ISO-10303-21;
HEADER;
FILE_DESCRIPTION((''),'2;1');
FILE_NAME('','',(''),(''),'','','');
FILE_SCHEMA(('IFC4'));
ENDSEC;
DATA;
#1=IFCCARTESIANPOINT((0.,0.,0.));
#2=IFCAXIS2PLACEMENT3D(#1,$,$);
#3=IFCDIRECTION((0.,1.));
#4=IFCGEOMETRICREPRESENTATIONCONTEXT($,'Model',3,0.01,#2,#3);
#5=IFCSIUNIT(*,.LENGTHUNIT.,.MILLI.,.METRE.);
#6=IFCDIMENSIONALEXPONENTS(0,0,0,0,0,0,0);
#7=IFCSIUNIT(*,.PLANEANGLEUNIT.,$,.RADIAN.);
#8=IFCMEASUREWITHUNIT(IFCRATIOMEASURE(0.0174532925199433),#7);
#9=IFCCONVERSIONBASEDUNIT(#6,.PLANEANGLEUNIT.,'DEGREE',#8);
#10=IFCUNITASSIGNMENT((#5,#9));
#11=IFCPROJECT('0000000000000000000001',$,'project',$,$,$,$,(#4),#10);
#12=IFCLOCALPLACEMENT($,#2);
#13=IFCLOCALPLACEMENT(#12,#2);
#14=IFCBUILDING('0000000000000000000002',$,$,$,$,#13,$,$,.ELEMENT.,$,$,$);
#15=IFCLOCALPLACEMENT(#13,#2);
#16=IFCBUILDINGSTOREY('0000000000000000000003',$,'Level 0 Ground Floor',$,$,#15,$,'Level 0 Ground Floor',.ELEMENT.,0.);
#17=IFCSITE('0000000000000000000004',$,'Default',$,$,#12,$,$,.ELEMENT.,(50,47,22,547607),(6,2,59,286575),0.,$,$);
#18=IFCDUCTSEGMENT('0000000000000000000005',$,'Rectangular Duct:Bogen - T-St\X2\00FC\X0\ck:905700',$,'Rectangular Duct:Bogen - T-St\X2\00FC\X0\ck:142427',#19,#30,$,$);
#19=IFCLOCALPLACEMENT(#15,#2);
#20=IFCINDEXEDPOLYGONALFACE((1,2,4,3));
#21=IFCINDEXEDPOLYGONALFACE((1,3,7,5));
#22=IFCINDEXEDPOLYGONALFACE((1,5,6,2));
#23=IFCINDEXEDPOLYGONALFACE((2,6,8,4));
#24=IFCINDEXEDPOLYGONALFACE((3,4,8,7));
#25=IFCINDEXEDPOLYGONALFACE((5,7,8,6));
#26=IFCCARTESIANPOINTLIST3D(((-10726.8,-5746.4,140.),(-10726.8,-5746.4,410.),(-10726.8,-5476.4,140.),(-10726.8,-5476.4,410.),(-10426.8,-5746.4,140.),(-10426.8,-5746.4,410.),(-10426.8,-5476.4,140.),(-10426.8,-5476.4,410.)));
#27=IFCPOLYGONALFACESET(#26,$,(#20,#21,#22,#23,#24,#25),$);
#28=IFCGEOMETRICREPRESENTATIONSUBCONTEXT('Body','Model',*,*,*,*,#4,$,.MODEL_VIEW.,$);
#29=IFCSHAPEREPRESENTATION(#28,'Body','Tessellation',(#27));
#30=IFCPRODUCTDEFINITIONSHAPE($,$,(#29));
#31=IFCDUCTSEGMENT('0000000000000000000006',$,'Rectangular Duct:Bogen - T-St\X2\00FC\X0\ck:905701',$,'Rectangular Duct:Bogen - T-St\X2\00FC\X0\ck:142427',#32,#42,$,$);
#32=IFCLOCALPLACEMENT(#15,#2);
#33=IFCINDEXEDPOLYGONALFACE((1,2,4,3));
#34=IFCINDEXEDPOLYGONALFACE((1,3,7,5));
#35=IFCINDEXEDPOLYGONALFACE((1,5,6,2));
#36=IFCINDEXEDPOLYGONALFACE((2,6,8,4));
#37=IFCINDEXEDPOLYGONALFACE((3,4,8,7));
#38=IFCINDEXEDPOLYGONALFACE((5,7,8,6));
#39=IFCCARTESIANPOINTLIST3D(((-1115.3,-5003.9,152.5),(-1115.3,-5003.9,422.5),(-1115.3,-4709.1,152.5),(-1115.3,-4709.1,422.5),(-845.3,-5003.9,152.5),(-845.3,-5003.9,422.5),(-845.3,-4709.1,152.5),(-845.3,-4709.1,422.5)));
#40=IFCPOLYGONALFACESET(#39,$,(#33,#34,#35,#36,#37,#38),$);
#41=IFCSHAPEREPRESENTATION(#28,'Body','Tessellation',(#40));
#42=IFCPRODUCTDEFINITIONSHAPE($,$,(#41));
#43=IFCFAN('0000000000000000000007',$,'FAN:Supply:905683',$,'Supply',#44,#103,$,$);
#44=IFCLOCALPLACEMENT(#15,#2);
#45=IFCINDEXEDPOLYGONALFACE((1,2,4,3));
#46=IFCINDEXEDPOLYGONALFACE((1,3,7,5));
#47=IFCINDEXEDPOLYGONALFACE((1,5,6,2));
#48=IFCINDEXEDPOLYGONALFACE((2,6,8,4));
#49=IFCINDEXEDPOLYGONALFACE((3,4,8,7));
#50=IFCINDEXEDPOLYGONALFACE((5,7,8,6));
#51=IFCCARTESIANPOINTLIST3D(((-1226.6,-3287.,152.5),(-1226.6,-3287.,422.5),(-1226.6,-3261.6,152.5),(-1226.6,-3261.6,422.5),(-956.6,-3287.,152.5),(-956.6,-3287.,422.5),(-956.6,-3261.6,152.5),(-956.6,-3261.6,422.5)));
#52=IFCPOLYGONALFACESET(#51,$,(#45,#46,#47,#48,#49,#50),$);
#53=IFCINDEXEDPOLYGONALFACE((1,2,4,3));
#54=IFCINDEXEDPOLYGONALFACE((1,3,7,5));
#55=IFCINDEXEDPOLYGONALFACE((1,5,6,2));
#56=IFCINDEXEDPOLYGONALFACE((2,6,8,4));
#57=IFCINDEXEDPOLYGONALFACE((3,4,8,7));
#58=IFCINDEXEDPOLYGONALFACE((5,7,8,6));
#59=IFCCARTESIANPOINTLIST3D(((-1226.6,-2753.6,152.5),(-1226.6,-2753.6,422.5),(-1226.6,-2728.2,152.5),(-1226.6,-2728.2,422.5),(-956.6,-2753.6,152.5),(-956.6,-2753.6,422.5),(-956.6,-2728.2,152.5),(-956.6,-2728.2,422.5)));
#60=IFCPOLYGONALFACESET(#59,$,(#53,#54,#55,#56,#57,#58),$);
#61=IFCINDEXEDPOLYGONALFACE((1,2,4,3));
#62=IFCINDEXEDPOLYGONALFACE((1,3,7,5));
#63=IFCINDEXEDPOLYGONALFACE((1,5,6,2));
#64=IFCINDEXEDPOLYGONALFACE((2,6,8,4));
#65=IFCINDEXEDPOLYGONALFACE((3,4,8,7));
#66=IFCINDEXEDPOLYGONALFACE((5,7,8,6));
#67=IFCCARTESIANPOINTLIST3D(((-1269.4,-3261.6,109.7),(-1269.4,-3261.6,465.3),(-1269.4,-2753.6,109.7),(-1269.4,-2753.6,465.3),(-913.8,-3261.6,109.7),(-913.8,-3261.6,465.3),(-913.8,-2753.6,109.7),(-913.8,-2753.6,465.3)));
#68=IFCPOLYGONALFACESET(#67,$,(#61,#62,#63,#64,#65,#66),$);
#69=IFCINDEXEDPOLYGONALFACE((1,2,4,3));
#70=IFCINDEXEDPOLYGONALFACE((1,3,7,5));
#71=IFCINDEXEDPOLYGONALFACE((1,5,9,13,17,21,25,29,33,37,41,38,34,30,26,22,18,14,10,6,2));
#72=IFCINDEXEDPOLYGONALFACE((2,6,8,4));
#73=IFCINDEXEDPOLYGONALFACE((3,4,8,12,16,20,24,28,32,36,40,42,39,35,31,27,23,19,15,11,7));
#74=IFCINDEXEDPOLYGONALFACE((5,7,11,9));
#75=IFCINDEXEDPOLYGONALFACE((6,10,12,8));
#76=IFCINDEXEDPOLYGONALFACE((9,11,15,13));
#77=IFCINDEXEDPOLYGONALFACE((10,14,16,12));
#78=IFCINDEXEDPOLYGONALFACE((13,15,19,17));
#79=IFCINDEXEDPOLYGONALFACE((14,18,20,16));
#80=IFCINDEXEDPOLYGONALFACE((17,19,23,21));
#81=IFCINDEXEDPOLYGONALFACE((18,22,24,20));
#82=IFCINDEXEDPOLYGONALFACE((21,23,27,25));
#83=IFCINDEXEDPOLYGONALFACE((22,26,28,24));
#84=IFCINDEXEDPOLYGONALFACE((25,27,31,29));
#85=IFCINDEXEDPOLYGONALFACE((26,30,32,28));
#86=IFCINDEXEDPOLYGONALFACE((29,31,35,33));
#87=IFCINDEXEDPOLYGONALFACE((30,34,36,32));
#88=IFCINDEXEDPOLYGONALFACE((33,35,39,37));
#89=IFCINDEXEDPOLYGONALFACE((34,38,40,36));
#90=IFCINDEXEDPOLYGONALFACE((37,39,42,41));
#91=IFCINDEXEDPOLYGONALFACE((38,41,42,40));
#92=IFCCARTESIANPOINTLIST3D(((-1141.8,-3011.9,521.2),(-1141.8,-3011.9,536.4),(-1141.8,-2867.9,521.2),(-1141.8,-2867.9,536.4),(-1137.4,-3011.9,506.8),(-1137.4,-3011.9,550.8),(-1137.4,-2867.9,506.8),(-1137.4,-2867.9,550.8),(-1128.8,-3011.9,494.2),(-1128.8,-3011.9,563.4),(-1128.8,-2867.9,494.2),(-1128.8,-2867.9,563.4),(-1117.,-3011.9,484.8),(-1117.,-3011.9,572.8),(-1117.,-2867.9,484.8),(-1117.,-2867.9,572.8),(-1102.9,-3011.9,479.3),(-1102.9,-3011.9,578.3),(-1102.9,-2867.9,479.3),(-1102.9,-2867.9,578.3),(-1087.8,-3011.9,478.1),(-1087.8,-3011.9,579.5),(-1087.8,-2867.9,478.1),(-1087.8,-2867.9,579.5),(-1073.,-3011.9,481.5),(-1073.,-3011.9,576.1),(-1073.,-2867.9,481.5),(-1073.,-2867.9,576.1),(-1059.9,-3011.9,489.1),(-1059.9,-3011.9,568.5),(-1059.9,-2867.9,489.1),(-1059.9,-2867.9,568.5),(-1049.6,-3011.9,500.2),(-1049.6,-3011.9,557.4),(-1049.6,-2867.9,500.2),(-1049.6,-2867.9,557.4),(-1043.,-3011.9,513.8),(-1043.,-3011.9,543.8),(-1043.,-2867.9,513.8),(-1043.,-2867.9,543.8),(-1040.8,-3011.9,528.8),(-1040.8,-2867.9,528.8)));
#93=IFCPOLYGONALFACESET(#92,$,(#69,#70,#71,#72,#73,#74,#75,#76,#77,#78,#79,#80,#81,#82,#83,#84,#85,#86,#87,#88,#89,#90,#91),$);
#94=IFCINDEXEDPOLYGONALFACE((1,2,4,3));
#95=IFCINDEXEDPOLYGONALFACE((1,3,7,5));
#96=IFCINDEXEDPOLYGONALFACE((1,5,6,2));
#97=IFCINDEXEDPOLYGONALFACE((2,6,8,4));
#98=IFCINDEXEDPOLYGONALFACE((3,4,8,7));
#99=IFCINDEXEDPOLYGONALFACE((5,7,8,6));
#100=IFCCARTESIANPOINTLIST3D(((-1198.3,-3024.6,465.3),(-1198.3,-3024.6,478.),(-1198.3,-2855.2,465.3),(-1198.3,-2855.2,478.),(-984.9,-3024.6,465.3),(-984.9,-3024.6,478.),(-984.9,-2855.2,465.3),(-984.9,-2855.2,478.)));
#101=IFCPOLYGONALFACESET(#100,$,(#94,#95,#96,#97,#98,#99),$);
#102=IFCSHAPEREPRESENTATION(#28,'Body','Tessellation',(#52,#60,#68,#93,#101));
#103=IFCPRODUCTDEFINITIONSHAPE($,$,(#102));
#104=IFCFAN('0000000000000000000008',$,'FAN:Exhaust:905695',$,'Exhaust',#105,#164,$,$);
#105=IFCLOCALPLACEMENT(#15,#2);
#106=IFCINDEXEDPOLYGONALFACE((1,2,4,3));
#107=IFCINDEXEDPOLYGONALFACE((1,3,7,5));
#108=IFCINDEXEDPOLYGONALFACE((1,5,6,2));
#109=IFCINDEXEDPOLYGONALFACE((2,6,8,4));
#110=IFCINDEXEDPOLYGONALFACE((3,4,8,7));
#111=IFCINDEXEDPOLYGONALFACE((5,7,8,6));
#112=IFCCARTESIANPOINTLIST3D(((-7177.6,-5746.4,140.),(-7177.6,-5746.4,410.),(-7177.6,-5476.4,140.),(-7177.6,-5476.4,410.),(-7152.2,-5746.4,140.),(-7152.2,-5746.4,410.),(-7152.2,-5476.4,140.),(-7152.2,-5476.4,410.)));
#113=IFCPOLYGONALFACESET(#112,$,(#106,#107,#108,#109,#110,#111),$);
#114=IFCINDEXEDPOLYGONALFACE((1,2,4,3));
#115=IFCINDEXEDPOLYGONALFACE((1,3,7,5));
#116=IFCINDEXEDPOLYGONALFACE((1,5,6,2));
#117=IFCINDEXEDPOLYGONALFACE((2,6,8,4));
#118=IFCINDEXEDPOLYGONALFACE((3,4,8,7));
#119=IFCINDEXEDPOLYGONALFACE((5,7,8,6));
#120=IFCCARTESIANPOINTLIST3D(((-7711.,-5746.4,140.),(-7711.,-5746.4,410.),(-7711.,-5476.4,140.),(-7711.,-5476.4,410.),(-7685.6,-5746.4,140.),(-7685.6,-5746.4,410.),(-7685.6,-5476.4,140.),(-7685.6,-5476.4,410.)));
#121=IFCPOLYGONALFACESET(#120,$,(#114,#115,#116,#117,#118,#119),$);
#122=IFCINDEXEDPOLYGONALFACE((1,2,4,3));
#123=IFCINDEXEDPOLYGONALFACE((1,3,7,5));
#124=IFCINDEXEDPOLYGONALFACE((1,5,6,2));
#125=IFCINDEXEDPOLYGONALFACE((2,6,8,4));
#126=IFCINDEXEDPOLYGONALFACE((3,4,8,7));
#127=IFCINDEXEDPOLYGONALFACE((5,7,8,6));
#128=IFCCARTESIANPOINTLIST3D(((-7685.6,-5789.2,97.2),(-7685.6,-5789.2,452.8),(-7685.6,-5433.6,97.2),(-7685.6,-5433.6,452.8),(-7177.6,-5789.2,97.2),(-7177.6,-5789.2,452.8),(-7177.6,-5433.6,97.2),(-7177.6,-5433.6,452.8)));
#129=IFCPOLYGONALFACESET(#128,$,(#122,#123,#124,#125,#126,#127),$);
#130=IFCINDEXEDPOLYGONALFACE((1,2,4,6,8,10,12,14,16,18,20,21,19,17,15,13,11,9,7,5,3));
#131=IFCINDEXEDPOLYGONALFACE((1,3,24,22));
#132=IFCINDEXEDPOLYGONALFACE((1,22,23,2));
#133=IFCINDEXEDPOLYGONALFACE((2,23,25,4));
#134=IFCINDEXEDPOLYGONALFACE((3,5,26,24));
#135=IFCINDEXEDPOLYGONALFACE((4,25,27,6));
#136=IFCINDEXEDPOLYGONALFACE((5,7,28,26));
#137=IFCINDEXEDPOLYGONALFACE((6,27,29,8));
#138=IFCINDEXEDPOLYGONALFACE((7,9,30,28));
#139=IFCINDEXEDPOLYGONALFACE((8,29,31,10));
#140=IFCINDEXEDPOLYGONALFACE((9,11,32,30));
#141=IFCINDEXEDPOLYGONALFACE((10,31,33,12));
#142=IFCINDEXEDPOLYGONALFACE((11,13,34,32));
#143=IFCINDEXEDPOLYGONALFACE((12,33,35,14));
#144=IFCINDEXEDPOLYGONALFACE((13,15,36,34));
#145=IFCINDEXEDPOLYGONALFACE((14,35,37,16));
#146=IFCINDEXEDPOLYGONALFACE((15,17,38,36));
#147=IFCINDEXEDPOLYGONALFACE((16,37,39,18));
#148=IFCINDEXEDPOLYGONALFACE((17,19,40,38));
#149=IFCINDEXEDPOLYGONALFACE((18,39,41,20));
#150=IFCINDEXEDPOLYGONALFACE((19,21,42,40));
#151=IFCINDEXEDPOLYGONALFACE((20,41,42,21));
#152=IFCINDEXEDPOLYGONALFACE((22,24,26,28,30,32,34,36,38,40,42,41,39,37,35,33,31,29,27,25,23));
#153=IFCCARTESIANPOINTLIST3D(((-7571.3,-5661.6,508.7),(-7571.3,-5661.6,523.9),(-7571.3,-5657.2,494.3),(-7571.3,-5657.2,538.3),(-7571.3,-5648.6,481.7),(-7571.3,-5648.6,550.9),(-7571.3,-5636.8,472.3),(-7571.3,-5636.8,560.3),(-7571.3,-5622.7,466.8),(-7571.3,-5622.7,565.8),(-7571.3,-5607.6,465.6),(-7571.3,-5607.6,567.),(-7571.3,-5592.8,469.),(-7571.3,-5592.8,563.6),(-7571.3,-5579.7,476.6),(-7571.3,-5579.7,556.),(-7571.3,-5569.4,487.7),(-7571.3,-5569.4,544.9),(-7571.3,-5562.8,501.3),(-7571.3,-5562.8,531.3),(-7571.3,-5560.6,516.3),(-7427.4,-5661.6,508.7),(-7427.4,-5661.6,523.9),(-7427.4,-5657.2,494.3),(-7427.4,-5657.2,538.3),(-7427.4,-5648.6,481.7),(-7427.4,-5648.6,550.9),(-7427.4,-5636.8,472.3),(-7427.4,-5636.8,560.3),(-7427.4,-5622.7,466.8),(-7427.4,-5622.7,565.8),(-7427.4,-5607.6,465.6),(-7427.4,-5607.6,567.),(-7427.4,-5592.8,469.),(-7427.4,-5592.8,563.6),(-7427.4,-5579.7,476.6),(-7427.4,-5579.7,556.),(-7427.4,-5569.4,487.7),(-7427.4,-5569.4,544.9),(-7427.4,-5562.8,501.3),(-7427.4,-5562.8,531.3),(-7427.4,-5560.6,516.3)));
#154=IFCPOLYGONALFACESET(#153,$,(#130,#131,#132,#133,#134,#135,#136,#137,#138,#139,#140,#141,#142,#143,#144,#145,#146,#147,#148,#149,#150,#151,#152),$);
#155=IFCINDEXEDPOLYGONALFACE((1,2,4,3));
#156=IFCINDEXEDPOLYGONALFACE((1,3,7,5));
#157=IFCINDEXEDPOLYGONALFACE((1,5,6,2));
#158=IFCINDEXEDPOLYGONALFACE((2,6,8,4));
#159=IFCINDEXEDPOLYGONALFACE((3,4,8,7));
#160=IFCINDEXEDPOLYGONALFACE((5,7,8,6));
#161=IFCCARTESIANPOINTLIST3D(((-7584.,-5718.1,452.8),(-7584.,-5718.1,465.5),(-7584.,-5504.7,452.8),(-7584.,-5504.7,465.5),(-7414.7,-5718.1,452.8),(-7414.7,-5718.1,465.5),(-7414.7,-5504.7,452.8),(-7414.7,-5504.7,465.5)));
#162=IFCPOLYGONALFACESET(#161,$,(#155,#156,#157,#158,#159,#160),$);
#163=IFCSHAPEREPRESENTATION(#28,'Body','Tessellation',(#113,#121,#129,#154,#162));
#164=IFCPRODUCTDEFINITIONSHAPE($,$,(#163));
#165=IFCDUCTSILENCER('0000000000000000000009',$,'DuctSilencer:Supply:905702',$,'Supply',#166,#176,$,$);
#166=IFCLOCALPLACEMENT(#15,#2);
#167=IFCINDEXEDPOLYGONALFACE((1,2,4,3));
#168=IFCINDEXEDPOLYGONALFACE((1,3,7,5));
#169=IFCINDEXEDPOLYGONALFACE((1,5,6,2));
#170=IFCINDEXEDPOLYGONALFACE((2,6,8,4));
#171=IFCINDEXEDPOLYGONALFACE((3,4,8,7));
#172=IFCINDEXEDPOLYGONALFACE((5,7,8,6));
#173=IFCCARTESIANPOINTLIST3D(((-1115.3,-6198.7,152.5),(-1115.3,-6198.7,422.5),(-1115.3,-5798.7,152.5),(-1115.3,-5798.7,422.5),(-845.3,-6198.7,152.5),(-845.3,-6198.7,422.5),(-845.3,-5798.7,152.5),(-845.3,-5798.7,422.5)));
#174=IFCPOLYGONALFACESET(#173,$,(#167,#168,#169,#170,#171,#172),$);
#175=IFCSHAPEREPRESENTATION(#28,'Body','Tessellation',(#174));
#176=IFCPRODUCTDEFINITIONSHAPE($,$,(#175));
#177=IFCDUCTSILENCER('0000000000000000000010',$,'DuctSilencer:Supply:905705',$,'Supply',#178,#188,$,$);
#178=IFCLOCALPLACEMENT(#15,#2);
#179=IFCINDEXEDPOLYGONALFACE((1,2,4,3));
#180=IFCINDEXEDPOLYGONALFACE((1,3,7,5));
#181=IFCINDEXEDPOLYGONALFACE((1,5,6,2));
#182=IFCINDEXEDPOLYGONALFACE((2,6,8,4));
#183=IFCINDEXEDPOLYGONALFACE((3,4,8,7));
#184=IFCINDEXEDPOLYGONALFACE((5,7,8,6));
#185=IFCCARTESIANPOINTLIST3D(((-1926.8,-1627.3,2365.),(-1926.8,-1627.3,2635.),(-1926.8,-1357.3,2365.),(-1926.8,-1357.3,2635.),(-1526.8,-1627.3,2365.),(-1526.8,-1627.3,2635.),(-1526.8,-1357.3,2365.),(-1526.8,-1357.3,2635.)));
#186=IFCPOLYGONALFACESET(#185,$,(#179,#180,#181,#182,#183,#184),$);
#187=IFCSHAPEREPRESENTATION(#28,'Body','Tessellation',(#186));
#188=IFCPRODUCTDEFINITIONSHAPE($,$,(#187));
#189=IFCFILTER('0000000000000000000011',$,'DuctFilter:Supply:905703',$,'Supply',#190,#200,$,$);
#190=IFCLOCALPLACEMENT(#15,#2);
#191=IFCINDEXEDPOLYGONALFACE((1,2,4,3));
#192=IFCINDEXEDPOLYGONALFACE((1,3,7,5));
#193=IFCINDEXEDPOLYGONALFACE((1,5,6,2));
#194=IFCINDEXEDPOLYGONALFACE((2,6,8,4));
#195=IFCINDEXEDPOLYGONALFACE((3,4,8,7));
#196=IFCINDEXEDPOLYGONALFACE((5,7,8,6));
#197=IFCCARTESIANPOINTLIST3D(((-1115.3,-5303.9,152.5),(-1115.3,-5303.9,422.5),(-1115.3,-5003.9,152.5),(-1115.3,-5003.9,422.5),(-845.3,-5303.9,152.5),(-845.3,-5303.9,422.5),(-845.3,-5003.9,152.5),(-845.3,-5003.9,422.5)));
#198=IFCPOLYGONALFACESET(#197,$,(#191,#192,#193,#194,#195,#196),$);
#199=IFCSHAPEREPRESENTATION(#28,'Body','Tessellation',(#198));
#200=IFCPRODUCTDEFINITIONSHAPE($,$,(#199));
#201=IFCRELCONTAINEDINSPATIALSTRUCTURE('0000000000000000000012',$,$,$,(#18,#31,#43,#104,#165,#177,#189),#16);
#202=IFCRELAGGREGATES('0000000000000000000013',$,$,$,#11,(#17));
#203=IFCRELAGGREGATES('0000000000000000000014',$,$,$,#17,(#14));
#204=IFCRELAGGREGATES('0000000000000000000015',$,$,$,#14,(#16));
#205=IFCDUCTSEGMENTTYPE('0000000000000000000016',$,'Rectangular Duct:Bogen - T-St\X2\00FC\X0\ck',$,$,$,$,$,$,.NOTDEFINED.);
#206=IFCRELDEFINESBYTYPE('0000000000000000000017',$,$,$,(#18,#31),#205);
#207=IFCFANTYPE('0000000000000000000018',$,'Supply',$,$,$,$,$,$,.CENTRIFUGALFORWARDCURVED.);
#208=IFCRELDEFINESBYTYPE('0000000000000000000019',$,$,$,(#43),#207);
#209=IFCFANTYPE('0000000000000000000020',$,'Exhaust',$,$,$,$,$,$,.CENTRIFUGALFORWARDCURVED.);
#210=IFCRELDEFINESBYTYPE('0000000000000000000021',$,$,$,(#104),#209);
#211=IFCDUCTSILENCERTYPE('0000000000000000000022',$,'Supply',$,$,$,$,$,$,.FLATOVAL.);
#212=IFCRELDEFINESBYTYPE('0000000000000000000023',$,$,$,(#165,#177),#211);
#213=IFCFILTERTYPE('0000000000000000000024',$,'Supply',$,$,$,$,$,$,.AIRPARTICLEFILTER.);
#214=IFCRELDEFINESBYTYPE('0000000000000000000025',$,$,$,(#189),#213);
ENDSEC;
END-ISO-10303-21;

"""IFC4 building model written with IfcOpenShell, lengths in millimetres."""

from ifc_helpers import new_model, entity, si_unit, converted_unit, direction, frame, frame_2d, origin, origin_2d_with_axis, place, context, subcontext, project, spatial, rectangle, circle, extrude, source, transform, mapped, type_object, type_shapes, element, save


model = new_model("IFC4")

# Units and contexts
model_context = context("Model", 3, precision=0.01, world=origin(), true_north=direction((0.0, 1.0)))
body_context = subcontext(model_context, "Body", "Model", "MODEL_VIEW")
ifc_project = project(units=[si_unit("LENGTHUNIT", "METRE", prefix="MILLI"), converted_unit("PLANEANGLEUNIT", "DEGREE", entity("IfcRatioMeasure", 0.0174532925199433), si_unit("PLANEANGLEUNIT", "RADIAN"), dimensions=[0, 0, 0, 0, 0, 0, 0])], contexts=[model_context])

# Site, building, storey
site_placement = place(None, origin())
site = spatial("IfcSite", under=ifc_project, at=site_placement, Name="Default", CompositionType="ELEMENT", RefLatitude=(50, 47, 22, 547607), RefLongitude=(6, 2, 59, 286575), RefElevation=0.0)
building_placement = place(site_placement, origin())
building = spatial("IfcBuilding", under=site, at=building_placement, CompositionType="ELEMENT")
storey_placement = place(building_placement, origin())
storey = spatial("IfcBuildingStorey", under=building, at=storey_placement, Name="Level 0 Ground Floor", LongName="Level 0 Ground Floor", CompositionType="ELEMENT", Elevation=0.0)

# Duct segments
duct_segment_type = type_object("IfcDuctSegmentType", Name="Rectangular Duct:Bogen - T-Stück", PredefinedType="NOTDEFINED")
duct_segment_1_placement = place(storey_placement, frame((-10726.8, -5746.4, 140.0)))
element("IfcDuctSegment", 1, at=duct_segment_1_placement, inside=storey, type_object=duct_segment_type, Name="Rectangular Duct:Bogen - T-Stück:905700", ObjectType="Rectangular Duct:Bogen - T-Stück:142427", context=body_context, shape_type="SweptSolid", body=[
    extrude(rectangle(XDim=300.0, YDim=270.0, at=frame_2d((0.0, 0.0), x_axis=(1.0, 0.0))), frame((150.0, 135.0, 0.0)), (0.0, 0.0, 1.0), 270.0),
])
duct_segment_2_placement = place(storey_placement, frame((-1115.3, -5003.9, 152.5)))
element("IfcDuctSegment", 2, at=duct_segment_2_placement, inside=storey, type_object=duct_segment_type, Name="Rectangular Duct:Bogen - T-Stück:905701", ObjectType="Rectangular Duct:Bogen - T-Stück:142427", context=body_context, shape_type="SweptSolid", body=[
    extrude(rectangle(XDim=294.8, YDim=270.0, at=frame_2d((0.0, 0.0), x_axis=(1.0, 0.0))), frame((135.0, 147.4, 0.0), z_axis=(0.0, 0.0, 1.0), x_axis=(0.0, -1.0, 0.0)), (0.0, 0.0, 1.0), 270.0),
])

# Fans
fan_type_1 = type_object("IfcFanType", Name="Supply", PredefinedType="CENTRIFUGALFORWARDCURVED")
shared_shape_1 = source(origin(), body_context, "Body", "SweptSolid", [
    extrude(rectangle(XDim=270.0, YDim=25.4, at=origin_2d_with_axis()), frame((0.0, -520.7, 42.8), z_axis=(0.0, 0.0, 1.0), x_axis=(-1.0, 0.0, 0.0)), (0.0, 0.0, 1.0), 270.0),
    extrude(rectangle(XDim=270.0, YDim=25.4, at=frame_2d((0.0, 0.0), x_axis=(1.0, 0.0))), frame((0.0, 12.7, 42.8), z_axis=(0.0, 0.0, 1.0), x_axis=(-1.0, 0.0, 0.0)), (0.0, 0.0, 1.0), 270.0),
    extrude(rectangle(XDim=355.6, YDim=508.0, at=origin_2d_with_axis()), frame((0.0, -254.0, 0.0), z_axis=(0.0, 0.0, 1.0), x_axis=(-1.0, 0.0, 0.0)), (0.0, 0.0, 1.0), 355.6),
    extrude(circle(Radius=50.8, at=frame_2d((0.0, 0.0), x_axis=(1.0, 0.0))), frame((0.0, -258.2, 419.1), z_axis=(0.0, 1.0, 0.0), x_axis=(1.0, 0.0, 0.0)), (0.0, 0.0, 1.0), 143.9),
    extrude(rectangle(XDim=213.4, YDim=169.3, at=origin_2d_with_axis()), frame((0.0, -186.3, 355.6), z_axis=(0.0, 0.0, 1.0), x_axis=(-1.0, 0.0, 0.0)), (0.0, 0.0, 1.0), 12.7),
])
type_shapes(fan_type_1, [shared_shape_1])
fan_1_placement = place(storey_placement, frame((-1091.6, -2753.6, 109.7)))
element("IfcFan", 3, at=fan_1_placement, inside=storey, type_object=fan_type_1, Name="FAN:Supply:905683", ObjectType="Supply", context=body_context, shape_type="MappedRepresentation", body=[
    mapped(shared_shape_1, transform((0.0, 0.0, 0.0), scale=1.0)),
])
fan_type_2 = type_object("IfcFanType", Name="Exhaust", PredefinedType="CENTRIFUGALFORWARDCURVED")
shared_shape_2 = source(origin(), body_context, "Body", "SweptSolid", [
    extrude(rectangle(XDim=270.0, YDim=25.4, at=origin_2d_with_axis()), frame((0.0, -520.7, 42.8), z_axis=(0.0, 0.0, 1.0), x_axis=(-1.0, 0.0, 0.0)), (0.0, 0.0, 1.0), 270.0),
    extrude(rectangle(XDim=270.0, YDim=25.4, at=frame_2d((0.0, 0.0), x_axis=(1.0, 0.0))), frame((0.0, 12.7, 42.8), z_axis=(0.0, 0.0, 1.0), x_axis=(-1.0, 0.0, 0.0)), (0.0, 0.0, 1.0), 270.0),
    extrude(rectangle(XDim=355.6, YDim=508.0, at=origin_2d_with_axis()), frame((0.0, -254.0, 0.0), z_axis=(0.0, 0.0, 1.0), x_axis=(-1.0, 0.0, 0.0)), (0.0, 0.0, 1.0), 355.6),
    extrude(circle(Radius=50.8, at=frame_2d((0.0, 0.0), x_axis=(1.0, 0.0))), frame((0.0, -258.2, 419.1), z_axis=(0.0, 1.0, 0.0), x_axis=(1.0, 0.0, 0.0)), (0.0, 0.0, 1.0), 143.9),
    extrude(rectangle(XDim=213.4, YDim=169.3, at=origin_2d_with_axis()), frame((0.0, -186.3, 355.6), z_axis=(0.0, 0.0, 1.0), x_axis=(-1.0, 0.0, 0.0)), (0.0, 0.0, 1.0), 12.7),
])
type_shapes(fan_type_2, [shared_shape_2])
fan_2_placement = place(storey_placement, frame((-7685.6, -5611.4, 97.2), z_axis=(0.0, 0.0, 1.0), x_axis=(0.0, 1.0, 0.0)))
element("IfcFan", 4, at=fan_2_placement, inside=storey, type_object=fan_type_2, Name="FAN:Exhaust:905695", ObjectType="Exhaust", context=body_context, shape_type="MappedRepresentation", body=[
    mapped(shared_shape_2, transform((0.0, 0.0, 0.0), scale=1.0)),
])

# Duct silencers
duct_silencer_type_1 = type_object("IfcDuctSilencerType", Name="Supply", PredefinedType="FLATOVAL")
shared_shape_3 = source(origin(), body_context, "Body", "SweptSolid", [
    extrude(rectangle(XDim=400.0, YDim=270.0, at=origin_2d_with_axis()), frame((0.0, 0.0, -135.0), z_axis=(0.0, 0.0, 1.0), x_axis=(-1.0, 0.0, 0.0)), (0.0, 0.0, 1.0), 270.0),
])
type_shapes(duct_silencer_type_1, [shared_shape_3])
duct_silencer_1_placement = place(storey_placement, frame((-980.3, -5998.7, 287.5), z_axis=(0.0, 0.0, 1.0), x_axis=(0.0, 1.0, 0.0)))
element("IfcDuctSilencer", 5, at=duct_silencer_1_placement, inside=storey, type_object=duct_silencer_type_1, Name="DuctSilencer:Supply:905702", ObjectType="Supply", context=body_context, shape_type="MappedRepresentation", body=[
    mapped(shared_shape_3, transform((0.0, 0.0, 0.0), scale=1.0)),
])
duct_silencer_2_placement = place(storey_placement, frame((-1726.8, -1492.3, 2500.0)))
element("IfcDuctSilencer", 6, at=duct_silencer_2_placement, inside=storey, type_object=duct_silencer_type_1, Name="DuctSilencer:Supply:905705", ObjectType="Supply", context=body_context, shape_type="MappedRepresentation", body=[
    mapped(shared_shape_3, transform((0.0, 0.0, 0.0), scale=1.0)),
])

# Filter
filter_type_1 = type_object("IfcFilterType", Name="Supply", PredefinedType="AIRPARTICLEFILTER")
shared_shape_4 = source(origin(), body_context, "Body", "SweptSolid", [
    extrude(rectangle(XDim=300.0, YDim=270.0, at=frame_2d((0.0, 0.0), x_axis=(1.0, 0.0))), frame((0.0, 0.0, -135.0), z_axis=(0.0, 0.0, 1.0), x_axis=(-1.0, 0.0, 0.0)), (0.0, 0.0, 1.0), 270.0),
])
type_shapes(filter_type_1, [shared_shape_4])
for number, where, z_axis, x_axis, name in (
    (7, (-980.3, -5153.9, 287.5), (0.0, 0.0, 1.0), (0.0, 1.0, 0.0), "DuctFilter:Supply:905703"),
):
    element("IfcFilter", number, at=place(storey_placement, frame(where, z_axis=z_axis, x_axis=x_axis)), inside=storey, type_object=filter_type_1, Name=name, ObjectType="Supply", context=body_context, shape_type="MappedRepresentation", body=[
        mapped(shared_shape_4, transform((0.0, 0.0, 0.0), scale=1.0)),
    ])

save(model, "model.ifc")
